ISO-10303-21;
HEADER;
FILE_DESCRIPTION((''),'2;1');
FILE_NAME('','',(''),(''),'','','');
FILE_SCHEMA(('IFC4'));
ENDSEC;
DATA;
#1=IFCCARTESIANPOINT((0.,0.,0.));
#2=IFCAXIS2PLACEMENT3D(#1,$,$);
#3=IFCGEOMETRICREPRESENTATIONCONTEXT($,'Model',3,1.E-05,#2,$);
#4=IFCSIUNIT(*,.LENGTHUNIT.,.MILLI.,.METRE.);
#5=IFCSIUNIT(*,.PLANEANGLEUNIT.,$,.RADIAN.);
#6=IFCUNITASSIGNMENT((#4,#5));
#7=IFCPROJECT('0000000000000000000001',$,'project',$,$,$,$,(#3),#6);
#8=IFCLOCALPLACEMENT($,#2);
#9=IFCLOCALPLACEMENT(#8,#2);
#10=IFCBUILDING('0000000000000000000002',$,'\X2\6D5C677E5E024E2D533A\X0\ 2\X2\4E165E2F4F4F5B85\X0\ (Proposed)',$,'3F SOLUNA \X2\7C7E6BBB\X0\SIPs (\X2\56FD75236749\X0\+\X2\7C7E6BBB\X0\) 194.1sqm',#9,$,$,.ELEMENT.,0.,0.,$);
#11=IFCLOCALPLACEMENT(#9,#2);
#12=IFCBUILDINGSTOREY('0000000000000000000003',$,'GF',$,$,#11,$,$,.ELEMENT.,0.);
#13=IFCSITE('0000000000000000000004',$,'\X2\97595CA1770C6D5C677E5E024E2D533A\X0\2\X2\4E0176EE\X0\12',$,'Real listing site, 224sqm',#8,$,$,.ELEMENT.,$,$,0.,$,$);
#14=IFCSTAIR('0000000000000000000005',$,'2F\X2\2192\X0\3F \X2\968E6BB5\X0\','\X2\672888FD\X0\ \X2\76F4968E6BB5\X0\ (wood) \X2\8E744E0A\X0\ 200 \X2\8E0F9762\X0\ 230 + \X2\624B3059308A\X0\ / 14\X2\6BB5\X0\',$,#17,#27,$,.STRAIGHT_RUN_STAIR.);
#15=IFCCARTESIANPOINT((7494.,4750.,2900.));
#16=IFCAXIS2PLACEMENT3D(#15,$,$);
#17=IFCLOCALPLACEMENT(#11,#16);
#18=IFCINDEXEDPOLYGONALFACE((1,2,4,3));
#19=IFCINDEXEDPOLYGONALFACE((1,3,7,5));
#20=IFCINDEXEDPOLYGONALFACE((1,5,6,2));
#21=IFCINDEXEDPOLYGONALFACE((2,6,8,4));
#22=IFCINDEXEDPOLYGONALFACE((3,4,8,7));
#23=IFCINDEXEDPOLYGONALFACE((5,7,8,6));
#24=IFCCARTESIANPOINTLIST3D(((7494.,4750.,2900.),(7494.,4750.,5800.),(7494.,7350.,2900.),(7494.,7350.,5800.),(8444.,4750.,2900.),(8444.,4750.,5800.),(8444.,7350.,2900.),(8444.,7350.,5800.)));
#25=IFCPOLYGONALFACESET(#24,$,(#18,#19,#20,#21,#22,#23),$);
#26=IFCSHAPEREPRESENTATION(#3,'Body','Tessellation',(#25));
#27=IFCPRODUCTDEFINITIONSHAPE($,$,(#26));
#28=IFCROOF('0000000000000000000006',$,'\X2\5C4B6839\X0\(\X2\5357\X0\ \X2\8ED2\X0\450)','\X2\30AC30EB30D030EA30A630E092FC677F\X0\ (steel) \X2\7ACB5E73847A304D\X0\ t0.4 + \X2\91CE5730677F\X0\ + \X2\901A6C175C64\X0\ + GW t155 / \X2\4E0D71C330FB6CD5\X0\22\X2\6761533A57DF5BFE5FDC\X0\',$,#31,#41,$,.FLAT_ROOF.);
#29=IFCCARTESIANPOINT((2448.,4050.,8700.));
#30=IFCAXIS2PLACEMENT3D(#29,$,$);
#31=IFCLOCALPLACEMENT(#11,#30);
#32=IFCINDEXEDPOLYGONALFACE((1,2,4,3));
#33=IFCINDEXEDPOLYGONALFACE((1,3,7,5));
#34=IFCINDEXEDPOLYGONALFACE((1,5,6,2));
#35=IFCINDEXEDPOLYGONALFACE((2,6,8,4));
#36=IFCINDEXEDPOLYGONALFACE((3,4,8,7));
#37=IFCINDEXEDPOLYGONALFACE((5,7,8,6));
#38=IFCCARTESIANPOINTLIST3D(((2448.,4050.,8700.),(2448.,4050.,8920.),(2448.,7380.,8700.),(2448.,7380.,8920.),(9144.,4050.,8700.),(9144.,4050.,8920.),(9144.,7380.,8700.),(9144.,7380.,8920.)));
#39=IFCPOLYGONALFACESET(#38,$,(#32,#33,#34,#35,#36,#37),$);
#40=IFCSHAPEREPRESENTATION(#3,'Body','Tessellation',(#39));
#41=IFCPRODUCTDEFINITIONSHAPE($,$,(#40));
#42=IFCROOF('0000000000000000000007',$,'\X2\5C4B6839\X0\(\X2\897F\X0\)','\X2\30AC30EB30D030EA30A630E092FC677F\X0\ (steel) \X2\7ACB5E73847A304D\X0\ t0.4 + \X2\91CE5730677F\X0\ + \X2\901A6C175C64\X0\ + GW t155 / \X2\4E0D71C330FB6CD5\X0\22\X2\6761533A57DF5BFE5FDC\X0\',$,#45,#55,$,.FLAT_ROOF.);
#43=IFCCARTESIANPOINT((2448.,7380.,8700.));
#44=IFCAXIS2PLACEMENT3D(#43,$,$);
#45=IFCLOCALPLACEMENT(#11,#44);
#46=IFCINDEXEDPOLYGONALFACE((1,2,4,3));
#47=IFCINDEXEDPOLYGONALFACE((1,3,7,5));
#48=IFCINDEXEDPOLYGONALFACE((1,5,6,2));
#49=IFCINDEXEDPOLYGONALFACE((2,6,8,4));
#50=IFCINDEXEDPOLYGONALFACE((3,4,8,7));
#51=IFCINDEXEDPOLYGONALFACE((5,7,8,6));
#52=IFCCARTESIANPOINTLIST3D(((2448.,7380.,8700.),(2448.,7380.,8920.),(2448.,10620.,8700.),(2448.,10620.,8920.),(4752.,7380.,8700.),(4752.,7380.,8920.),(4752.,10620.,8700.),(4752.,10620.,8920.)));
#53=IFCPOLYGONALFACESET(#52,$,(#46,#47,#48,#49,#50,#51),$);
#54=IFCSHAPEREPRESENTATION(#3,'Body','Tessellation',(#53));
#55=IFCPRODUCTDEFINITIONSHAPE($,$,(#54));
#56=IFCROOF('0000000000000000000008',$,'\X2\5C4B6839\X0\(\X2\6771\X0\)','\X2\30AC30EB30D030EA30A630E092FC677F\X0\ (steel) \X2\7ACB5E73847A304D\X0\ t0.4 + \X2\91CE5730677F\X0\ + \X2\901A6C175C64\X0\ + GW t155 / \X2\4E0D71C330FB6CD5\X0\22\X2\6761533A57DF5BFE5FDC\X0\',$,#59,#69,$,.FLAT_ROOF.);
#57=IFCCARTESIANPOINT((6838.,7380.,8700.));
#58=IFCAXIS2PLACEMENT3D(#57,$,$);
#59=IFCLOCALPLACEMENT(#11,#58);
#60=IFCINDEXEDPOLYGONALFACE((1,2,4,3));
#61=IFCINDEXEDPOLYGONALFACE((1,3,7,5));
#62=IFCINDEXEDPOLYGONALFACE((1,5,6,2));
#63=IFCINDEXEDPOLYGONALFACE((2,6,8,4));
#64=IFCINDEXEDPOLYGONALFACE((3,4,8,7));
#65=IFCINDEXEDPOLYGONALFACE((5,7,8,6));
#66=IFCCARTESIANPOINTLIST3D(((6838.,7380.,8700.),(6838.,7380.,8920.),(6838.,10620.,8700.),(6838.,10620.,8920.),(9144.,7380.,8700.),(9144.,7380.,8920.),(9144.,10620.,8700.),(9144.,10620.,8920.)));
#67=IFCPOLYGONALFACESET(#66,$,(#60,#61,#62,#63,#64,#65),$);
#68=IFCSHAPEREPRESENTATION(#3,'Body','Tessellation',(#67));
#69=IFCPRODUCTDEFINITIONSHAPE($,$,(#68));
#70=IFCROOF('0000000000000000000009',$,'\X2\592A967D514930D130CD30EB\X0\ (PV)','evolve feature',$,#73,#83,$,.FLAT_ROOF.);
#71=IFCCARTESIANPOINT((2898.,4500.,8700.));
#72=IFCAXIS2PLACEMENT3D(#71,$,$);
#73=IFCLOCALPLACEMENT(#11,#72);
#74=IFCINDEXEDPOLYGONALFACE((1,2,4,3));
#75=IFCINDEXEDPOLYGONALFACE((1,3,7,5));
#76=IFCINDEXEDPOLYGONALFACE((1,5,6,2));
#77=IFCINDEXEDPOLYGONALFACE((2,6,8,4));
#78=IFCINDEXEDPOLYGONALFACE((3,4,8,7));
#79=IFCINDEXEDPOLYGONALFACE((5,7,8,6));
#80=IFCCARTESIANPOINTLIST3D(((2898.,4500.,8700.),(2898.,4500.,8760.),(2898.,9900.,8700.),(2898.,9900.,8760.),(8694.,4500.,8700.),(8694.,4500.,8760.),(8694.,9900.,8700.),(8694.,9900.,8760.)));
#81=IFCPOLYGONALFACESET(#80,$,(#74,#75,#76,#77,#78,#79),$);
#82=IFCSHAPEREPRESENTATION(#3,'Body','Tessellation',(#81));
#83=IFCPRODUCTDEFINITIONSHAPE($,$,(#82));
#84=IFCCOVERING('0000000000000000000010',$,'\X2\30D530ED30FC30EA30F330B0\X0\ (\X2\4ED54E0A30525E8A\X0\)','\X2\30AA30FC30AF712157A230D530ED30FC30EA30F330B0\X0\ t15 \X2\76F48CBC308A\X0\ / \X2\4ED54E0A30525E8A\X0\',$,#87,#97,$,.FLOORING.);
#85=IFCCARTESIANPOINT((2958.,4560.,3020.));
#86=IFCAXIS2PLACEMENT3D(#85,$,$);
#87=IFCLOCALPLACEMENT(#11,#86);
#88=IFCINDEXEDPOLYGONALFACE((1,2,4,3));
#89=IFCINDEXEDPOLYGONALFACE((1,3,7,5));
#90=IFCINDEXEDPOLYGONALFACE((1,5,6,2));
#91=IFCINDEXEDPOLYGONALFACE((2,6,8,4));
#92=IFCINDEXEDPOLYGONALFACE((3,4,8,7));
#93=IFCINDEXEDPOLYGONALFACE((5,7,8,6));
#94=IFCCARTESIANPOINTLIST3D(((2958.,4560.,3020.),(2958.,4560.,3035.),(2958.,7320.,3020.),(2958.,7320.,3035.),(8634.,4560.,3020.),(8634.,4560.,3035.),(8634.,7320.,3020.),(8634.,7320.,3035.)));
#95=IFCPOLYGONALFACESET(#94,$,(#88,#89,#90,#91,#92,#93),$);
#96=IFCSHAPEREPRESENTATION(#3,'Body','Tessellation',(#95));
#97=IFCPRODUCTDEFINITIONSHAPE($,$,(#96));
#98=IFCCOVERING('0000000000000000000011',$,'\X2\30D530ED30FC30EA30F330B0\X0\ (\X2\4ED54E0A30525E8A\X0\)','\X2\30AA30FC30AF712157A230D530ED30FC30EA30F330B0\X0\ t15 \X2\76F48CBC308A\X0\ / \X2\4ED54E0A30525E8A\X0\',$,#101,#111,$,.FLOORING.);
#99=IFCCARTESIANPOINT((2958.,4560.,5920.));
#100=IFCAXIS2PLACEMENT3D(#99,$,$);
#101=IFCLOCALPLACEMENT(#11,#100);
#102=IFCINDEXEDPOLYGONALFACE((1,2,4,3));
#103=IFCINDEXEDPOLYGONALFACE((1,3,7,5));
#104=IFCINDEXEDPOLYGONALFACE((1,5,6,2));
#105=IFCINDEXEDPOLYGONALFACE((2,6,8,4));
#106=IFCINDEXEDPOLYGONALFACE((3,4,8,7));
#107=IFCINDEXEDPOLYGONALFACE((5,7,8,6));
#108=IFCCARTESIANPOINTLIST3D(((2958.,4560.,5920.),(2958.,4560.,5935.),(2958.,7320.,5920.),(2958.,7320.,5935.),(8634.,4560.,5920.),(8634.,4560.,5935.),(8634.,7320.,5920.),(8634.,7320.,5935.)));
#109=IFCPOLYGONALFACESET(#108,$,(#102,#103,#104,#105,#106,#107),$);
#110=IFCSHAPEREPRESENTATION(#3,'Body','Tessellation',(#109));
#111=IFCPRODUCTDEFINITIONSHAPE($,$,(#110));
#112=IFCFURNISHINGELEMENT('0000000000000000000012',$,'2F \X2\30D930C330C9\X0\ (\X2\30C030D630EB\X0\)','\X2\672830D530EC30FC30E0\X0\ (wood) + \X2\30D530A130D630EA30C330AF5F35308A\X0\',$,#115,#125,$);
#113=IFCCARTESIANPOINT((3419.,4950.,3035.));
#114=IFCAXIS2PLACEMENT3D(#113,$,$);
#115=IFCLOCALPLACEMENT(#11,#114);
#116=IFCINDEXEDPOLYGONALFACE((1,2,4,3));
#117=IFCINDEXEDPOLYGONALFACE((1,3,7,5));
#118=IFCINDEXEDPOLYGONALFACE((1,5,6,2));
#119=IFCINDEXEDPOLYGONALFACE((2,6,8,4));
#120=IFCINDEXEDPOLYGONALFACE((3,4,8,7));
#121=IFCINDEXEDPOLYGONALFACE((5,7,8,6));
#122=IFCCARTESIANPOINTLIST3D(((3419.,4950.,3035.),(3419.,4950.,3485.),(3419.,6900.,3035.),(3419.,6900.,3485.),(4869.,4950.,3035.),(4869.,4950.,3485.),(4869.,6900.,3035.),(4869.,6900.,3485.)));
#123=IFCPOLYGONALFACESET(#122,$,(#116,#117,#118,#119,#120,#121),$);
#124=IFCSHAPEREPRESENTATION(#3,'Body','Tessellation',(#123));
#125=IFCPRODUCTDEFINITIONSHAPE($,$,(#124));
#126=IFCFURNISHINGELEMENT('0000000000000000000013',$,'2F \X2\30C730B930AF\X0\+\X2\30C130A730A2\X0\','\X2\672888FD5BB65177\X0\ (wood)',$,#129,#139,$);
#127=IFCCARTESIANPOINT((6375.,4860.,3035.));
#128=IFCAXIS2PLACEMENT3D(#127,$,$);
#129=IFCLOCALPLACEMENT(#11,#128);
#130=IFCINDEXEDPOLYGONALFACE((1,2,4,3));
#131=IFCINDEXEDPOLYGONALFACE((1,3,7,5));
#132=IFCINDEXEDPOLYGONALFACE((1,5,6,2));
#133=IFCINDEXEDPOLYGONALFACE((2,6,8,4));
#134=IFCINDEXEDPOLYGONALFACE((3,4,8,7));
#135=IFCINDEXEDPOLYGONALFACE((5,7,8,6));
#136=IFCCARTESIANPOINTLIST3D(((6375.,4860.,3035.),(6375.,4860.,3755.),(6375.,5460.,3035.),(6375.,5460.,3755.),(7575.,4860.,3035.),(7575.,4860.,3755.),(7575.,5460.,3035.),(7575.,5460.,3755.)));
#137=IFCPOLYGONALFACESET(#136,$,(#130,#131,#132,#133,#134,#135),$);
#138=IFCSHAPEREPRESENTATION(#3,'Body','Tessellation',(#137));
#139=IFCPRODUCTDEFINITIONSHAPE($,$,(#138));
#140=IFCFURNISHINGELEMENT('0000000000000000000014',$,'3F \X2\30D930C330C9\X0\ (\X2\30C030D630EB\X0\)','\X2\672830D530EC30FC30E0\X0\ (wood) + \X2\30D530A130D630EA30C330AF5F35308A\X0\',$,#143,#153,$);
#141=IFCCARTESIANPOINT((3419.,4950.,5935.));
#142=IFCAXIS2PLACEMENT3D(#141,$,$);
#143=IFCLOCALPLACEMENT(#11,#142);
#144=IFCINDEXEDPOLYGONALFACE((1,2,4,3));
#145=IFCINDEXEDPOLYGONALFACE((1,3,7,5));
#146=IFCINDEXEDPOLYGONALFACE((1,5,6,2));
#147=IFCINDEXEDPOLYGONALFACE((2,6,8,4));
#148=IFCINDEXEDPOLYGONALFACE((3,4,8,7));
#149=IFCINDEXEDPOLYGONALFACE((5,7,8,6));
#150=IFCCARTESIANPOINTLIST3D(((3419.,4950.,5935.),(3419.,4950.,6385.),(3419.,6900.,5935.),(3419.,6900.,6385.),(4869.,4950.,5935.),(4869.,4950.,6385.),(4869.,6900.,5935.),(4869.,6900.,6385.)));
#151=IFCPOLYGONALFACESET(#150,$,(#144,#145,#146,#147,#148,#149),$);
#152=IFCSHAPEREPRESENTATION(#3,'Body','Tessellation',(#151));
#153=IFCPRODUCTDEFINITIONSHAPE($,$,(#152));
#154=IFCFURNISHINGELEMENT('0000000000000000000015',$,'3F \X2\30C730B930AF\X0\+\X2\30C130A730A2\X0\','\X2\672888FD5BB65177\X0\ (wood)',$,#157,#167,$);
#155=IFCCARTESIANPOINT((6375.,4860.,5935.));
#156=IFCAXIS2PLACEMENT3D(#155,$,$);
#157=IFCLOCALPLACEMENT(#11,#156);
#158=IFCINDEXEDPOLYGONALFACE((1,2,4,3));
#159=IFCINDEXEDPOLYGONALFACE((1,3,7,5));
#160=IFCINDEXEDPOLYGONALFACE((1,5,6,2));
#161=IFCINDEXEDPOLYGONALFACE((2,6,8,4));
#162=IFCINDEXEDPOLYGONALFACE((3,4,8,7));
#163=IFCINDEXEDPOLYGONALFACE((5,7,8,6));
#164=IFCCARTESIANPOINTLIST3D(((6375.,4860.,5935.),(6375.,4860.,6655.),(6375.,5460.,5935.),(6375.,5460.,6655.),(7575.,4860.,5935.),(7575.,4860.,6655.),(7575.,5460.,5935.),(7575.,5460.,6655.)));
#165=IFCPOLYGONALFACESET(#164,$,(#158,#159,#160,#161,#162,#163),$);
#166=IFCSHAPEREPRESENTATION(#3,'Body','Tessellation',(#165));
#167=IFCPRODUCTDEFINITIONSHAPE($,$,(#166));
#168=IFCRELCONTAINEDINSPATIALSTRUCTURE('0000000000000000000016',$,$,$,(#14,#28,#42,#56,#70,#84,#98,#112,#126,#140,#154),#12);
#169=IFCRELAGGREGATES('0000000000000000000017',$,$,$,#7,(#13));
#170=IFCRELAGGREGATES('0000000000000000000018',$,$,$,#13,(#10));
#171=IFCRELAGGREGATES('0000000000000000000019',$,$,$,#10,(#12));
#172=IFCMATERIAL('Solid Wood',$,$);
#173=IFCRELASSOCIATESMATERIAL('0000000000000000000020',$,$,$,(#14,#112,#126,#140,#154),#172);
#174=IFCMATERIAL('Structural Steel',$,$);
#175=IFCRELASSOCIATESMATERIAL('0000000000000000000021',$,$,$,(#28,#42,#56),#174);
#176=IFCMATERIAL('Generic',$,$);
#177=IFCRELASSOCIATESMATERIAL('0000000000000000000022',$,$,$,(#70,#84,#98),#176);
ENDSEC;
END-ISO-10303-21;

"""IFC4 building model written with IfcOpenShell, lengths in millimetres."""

from ifc_helpers import new_model, si_unit, frame, frame_2d, origin, place, context, project, spatial, rectangle, extrude, material, element, save


model = new_model("IFC4")

# Units and contexts
model_context = context("Model", 3, precision=1e-05, world=origin())
ifc_project = project(units=[si_unit("LENGTHUNIT", "METRE", prefix="MILLI"), si_unit("PLANEANGLEUNIT", "RADIAN")], contexts=[model_context])

# Site, building, storey
site_placement = place(None, origin())
site = spatial("IfcSite", under=ifc_project, at=site_placement, Name="静岡県浜松市中区2丁目12", ObjectType="Real listing site, 224sqm", CompositionType="ELEMENT", RefElevation=0.0)
building_placement = place(site_placement, origin())
building = spatial("IfcBuilding", under=site, at=building_placement, Name="浜松市中区 2世帯住宅 (Proposed)", ObjectType="3F SOLUNA 籾殻SIPs (国産杉+籾殻) 194.1sqm", CompositionType="ELEMENT", ElevationOfRefHeight=0.0, ElevationOfTerrain=0.0)
storey_placement = place(building_placement, origin())
storey = spatial("IfcBuildingStorey", under=building, at=storey_placement, Name="GF", CompositionType="ELEMENT", Elevation=0.0)

# Shared definitions
ifc_material_1 = material(Name="Solid Wood")

# Stair
stair_placement = place(storey_placement, frame((7494.0, 4750.0, 2900.0)))
element("IfcStair", 1, at=stair_placement, inside=storey, material=ifc_material_1, Name="2F→3F 階段", Description="木製 直階段 (wood) 蹴上 200 踏面 230 + 手すり / 14段", PredefinedType="STRAIGHT_RUN_STAIR", context=model_context, shape_type="SweptSolid", body=[
    extrude(rectangle(XDim=950.0, YDim=2600.0, at=frame_2d((475.0, 1300.0))), frame((7494.0, 4750.0, 2900.0)), (0.0, 0.0, 1.0), 2900.0),
])

# Roofs
ifc_material_2 = material(Name="Structural Steel")
roof_1_placement = place(storey_placement, frame((2448.0, 4050.0, 8700.0)))
element("IfcRoof", 2, at=roof_1_placement, inside=storey, material=ifc_material_2, Name="屋根(南 軒450)", Description="ガルバリウム鋼板 (steel) 立平葺き t0.4 + 野地板 + 通気層 + GW t155 / 不燃・法22条区域対応", PredefinedType="FLAT_ROOF", context=model_context, shape_type="SweptSolid", body=[
    extrude(rectangle(XDim=6696.0, YDim=3330.0, at=frame_2d((3348.0, 1665.0))), frame((2448.0, 4050.0, 8700.0)), (0.0, 0.0, 1.0), 220.0),
])
roof_2_placement = place(storey_placement, frame((2448.0, 7380.0, 8700.0)))
element("IfcRoof", 3, at=roof_2_placement, inside=storey, material=ifc_material_2, Name="屋根(西)", Description="ガルバリウム鋼板 (steel) 立平葺き t0.4 + 野地板 + 通気層 + GW t155 / 不燃・法22条区域対応", PredefinedType="FLAT_ROOF", context=model_context, shape_type="SweptSolid", body=[
    extrude(rectangle(XDim=2304.0, YDim=3240.0, at=frame_2d((1152.0, 1620.0))), frame((2448.0, 7380.0, 8700.0)), (0.0, 0.0, 1.0), 220.0),
])
roof_3_placement = place(storey_placement, frame((6838.0, 7380.0, 8700.0)))
element("IfcRoof", 4, at=roof_3_placement, inside=storey, material=ifc_material_2, Name="屋根(東)", Description="ガルバリウム鋼板 (steel) 立平葺き t0.4 + 野地板 + 通気層 + GW t155 / 不燃・法22条区域対応", PredefinedType="FLAT_ROOF", context=model_context, shape_type="SweptSolid", body=[
    extrude(rectangle(XDim=2306.0, YDim=3240.0, at=frame_2d((1153.0, 1620.0))), frame((6838.0, 7380.0, 8700.0)), (0.0, 0.0, 1.0), 220.0),
])
ifc_material_3 = material(Name="Generic")
roof_4_placement = place(storey_placement, frame((2898.0, 4500.0, 8700.0)))
element("IfcRoof", 5, at=roof_4_placement, inside=storey, material=ifc_material_3, Name="太陽光パネル (PV)", Description="evolve feature", PredefinedType="FLAT_ROOF", context=model_context, shape_type="SweptSolid", body=[
    extrude(rectangle(XDim=5796.0, YDim=5400.0, at=frame_2d((2898.0, 2700.0))), frame((2898.0, 4500.0, 8700.0)), (0.0, 0.0, 1.0), 60.0),
])

# Coverings
covering_1_placement = place(storey_placement, frame((2958.0, 4560.0, 3020.0)))
element("IfcCovering", 6, at=covering_1_placement, inside=storey, material=ifc_material_3, Name="フローリング (仕上げ床)", Description="オーク無垢フローリング t15 直貼り / 仕上げ床", PredefinedType="FLOORING", context=model_context, shape_type="SweptSolid", body=[
    extrude(rectangle(XDim=5676.0, YDim=2760.0, at=frame_2d((2838.0, 1380.0))), frame((2958.0, 4560.0, 3020.0)), (0.0, 0.0, 1.0), 15.0),
])
covering_2_placement = place(storey_placement, frame((2958.0, 4560.0, 5920.0)))
element("IfcCovering", 7, at=covering_2_placement, inside=storey, material=ifc_material_3, Name="フローリング (仕上げ床)", Description="オーク無垢フローリング t15 直貼り / 仕上げ床", PredefinedType="FLOORING", context=model_context, shape_type="SweptSolid", body=[
    extrude(rectangle(XDim=5676.0, YDim=2760.0, at=frame_2d((2838.0, 1380.0))), frame((2958.0, 4560.0, 5920.0)), (0.0, 0.0, 1.0), 15.0),
])

# Furnishing elements
furnishing_1_placement = place(storey_placement, frame((3419.0, 4950.0, 3035.0)))
element("IfcFurnishingElement", 8, at=furnishing_1_placement, inside=storey, material=ifc_material_1, Name="2F ベッド (ダブル)", Description="木フレーム (wood) + ファブリック張り", context=model_context, shape_type="SweptSolid", body=[
    extrude(rectangle(XDim=1450.0, YDim=1950.0, at=frame_2d((725.0, 975.0))), frame((3419.0, 4950.0, 3035.0)), (0.0, 0.0, 1.0), 450.0),
])
furnishing_2_placement = place(storey_placement, frame((6375.0, 4860.0, 3035.0)))
element("IfcFurnishingElement", 9, at=furnishing_2_placement, inside=storey, material=ifc_material_1, Name="2F デスク+チェア", Description="木製家具 (wood)", context=model_context, shape_type="SweptSolid", body=[
    extrude(rectangle(XDim=1200.0, YDim=600.0, at=frame_2d((600.0, 300.0))), frame((6375.0, 4860.0, 3035.0)), (0.0, 0.0, 1.0), 720.0),
])
furnishing_3_placement = place(storey_placement, frame((3419.0, 4950.0, 5935.0)))
element("IfcFurnishingElement", 10, at=furnishing_3_placement, inside=storey, material=ifc_material_1, Name="3F ベッド (ダブル)", Description="木フレーム (wood) + ファブリック張り", context=model_context, shape_type="SweptSolid", body=[
    extrude(rectangle(XDim=1450.0, YDim=1950.0, at=frame_2d((725.0, 975.0))), frame((3419.0, 4950.0, 5935.0)), (0.0, 0.0, 1.0), 450.0),
])
furnishing_4_placement = place(storey_placement, frame((6375.0, 4860.0, 5935.0)))
element("IfcFurnishingElement", 11, at=furnishing_4_placement, inside=storey, material=ifc_material_1, Name="3F デスク+チェア", Description="木製家具 (wood)", context=model_context, shape_type="SweptSolid", body=[
    extrude(rectangle(XDim=1200.0, YDim=600.0, at=frame_2d((600.0, 300.0))), frame((6375.0, 4860.0, 5935.0)), (0.0, 0.0, 1.0), 720.0),
])

save(model, "model.ifc")
